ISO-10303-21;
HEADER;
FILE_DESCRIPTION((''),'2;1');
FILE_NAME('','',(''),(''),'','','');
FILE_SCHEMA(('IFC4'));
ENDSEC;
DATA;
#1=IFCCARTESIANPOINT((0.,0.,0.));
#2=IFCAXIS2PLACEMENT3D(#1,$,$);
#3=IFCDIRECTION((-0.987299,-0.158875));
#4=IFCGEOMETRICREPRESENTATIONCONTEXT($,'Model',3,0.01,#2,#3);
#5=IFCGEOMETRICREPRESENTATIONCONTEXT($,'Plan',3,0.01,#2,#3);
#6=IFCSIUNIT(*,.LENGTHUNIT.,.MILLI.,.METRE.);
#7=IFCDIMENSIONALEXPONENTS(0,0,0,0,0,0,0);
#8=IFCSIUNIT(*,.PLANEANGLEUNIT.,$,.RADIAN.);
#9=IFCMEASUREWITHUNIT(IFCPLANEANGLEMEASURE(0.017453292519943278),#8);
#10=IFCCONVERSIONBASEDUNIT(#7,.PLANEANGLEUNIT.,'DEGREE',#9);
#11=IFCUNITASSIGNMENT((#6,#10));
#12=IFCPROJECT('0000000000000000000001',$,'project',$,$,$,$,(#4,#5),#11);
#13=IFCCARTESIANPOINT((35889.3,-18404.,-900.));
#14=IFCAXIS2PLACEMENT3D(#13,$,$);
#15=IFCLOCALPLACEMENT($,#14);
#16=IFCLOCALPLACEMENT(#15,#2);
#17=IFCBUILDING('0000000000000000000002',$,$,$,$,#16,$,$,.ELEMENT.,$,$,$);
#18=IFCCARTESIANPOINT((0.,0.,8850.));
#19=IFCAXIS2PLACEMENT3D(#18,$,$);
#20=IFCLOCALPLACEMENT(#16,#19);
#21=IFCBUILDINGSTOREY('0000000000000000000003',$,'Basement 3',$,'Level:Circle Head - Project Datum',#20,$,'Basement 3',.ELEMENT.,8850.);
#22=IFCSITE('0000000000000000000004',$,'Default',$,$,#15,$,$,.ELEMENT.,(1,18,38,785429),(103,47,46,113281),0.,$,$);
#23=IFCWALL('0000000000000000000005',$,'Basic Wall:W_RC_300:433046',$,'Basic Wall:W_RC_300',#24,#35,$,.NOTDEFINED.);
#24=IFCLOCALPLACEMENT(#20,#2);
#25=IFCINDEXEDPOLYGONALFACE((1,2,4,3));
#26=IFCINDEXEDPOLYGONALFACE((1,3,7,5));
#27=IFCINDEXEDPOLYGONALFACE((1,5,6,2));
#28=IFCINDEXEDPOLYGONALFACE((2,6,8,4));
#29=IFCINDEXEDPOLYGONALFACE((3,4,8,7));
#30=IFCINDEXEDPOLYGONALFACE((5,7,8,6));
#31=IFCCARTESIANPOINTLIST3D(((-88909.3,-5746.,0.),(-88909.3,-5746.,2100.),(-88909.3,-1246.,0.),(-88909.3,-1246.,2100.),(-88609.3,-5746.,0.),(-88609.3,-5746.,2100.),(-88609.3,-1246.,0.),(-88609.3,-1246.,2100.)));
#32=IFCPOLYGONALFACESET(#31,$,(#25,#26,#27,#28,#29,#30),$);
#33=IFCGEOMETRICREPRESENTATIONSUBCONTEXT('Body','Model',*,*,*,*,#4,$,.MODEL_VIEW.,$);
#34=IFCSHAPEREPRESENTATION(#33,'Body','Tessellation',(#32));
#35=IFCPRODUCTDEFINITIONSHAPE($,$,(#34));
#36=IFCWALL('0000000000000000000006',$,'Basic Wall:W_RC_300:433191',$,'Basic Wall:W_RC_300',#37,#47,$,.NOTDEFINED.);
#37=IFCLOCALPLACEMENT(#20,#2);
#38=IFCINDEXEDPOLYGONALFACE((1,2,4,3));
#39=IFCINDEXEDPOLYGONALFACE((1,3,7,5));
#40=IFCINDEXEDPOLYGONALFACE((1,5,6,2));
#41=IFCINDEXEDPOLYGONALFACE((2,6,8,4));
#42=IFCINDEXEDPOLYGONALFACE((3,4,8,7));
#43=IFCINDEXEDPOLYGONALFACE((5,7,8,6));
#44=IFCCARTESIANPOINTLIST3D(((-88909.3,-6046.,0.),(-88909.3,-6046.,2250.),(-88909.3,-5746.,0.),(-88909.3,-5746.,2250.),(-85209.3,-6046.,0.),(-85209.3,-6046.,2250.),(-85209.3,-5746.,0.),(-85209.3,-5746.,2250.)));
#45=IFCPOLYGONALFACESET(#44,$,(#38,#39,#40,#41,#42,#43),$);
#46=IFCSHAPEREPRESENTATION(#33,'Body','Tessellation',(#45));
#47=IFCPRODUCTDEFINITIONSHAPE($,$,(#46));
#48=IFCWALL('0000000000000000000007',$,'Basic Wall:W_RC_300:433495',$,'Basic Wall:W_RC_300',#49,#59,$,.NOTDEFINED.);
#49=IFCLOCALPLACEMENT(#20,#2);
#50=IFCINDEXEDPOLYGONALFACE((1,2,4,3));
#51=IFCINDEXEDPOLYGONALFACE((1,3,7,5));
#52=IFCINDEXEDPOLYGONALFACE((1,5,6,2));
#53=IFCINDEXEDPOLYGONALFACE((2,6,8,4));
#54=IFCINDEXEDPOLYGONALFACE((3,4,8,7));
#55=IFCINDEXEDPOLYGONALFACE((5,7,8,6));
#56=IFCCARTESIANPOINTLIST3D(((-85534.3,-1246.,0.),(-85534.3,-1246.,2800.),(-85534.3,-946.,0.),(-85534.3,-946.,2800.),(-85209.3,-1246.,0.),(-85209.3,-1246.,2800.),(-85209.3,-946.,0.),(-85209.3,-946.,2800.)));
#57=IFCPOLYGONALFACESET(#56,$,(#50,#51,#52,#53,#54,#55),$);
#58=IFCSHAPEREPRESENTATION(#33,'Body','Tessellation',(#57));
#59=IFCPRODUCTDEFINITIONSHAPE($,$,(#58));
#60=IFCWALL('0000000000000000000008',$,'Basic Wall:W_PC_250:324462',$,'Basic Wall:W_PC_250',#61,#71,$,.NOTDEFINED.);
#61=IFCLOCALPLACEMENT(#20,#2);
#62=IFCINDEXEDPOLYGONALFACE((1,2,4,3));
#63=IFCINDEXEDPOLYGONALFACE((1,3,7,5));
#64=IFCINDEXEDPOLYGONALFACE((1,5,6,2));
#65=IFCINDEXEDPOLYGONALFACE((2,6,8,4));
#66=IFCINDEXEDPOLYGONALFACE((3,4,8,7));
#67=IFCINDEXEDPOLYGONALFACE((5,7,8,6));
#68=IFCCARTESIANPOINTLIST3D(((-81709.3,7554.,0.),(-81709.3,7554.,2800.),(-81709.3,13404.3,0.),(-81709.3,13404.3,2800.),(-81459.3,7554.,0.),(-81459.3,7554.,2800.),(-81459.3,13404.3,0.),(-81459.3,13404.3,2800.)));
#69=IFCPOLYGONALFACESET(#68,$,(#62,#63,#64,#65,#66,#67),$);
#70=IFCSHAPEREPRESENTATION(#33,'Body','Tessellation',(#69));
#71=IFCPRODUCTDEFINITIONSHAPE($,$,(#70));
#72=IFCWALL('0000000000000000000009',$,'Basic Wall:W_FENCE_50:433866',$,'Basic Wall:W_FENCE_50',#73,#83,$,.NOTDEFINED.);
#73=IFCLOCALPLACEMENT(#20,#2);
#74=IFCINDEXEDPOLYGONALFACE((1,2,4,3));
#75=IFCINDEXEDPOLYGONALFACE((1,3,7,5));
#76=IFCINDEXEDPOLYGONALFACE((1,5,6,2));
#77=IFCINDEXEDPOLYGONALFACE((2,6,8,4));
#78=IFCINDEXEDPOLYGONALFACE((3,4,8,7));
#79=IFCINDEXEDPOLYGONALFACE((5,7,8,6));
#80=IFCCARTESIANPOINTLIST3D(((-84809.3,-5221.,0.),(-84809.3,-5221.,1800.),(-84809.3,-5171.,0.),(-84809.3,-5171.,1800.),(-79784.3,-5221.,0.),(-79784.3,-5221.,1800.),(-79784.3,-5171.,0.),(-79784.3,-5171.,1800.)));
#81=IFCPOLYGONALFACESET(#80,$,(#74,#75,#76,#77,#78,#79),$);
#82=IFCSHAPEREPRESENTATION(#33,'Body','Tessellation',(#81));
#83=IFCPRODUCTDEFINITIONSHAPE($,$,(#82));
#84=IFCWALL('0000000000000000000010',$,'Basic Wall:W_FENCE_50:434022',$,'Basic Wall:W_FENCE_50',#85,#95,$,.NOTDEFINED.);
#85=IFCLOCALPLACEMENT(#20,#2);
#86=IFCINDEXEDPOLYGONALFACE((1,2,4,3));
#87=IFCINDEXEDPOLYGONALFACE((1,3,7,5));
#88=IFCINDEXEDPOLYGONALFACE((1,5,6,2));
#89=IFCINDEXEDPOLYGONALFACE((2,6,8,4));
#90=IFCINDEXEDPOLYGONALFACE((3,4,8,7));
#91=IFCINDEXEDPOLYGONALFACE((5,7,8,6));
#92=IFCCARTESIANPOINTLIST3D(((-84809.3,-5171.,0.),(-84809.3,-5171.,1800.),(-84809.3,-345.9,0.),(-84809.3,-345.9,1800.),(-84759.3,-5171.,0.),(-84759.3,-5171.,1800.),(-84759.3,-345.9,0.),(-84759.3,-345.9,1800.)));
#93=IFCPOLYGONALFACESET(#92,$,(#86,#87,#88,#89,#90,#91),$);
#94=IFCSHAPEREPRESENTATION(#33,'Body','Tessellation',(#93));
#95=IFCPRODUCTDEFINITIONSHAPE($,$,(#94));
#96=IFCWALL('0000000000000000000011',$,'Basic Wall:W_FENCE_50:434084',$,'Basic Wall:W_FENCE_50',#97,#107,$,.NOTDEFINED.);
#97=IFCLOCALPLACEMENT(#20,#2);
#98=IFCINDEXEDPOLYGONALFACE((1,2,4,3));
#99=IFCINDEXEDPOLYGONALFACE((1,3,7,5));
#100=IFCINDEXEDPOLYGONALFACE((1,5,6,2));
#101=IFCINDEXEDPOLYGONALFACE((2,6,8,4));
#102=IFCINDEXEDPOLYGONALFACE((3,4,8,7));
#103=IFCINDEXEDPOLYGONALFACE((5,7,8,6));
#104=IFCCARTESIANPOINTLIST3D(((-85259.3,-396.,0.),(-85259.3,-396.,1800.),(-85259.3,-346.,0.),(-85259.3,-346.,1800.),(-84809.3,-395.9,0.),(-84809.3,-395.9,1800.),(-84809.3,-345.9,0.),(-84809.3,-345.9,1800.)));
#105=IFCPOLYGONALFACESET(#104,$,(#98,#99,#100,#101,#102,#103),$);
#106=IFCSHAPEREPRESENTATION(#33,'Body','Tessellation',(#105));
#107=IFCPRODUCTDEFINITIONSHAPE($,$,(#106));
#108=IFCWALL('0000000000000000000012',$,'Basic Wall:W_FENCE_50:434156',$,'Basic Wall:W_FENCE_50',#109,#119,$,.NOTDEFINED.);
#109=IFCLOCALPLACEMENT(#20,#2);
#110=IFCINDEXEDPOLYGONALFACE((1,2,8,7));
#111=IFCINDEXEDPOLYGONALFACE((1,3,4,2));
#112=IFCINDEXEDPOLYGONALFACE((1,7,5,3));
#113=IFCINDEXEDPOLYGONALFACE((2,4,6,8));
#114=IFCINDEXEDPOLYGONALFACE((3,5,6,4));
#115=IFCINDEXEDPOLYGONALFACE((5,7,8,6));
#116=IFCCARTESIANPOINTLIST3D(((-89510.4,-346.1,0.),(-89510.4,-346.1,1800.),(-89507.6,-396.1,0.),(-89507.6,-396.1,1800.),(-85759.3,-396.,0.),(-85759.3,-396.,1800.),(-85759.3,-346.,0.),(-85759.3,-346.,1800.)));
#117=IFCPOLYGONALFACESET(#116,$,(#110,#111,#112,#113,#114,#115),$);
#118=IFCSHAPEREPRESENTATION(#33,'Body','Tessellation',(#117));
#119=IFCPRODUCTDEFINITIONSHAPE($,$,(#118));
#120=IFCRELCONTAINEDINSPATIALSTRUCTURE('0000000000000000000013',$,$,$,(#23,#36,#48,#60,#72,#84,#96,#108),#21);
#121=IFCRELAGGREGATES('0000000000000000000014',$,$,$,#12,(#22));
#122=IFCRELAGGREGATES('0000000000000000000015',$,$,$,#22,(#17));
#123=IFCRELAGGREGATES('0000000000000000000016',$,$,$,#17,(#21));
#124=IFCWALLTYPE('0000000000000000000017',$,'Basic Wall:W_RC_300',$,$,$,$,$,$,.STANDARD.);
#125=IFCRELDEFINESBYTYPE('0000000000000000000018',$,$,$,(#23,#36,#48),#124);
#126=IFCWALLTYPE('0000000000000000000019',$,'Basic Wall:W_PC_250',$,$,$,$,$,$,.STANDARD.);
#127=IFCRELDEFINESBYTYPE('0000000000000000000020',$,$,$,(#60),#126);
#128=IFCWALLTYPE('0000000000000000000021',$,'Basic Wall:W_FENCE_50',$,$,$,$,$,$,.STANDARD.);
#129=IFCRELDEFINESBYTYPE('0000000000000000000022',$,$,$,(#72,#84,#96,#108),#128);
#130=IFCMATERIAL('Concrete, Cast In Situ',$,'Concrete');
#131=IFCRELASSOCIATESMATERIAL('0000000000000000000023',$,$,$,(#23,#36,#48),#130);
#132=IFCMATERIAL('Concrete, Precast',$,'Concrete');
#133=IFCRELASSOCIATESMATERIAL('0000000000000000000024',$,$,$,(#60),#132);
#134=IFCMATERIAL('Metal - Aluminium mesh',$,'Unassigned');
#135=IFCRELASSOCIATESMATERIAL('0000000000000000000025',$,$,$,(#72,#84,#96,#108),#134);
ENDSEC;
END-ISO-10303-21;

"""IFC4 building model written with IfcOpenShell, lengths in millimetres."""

from ifc_helpers import new_model, entity, si_unit, converted_unit, direction, frame, origin, place, context, subcontext, project, spatial, indexed_curve, outline, extrude, material, type_object, element, save


model = new_model("IFC4")

# Units and contexts
model_context = context("Model", 3, precision=0.01, world=origin(), true_north=direction((-0.987299, -0.158875)))
plan_context = context("Plan", 3, precision=0.01, world=origin(), true_north=direction((-0.987299, -0.158875)))
body_context = subcontext(model_context, "Body", "Model", "MODEL_VIEW")
ifc_project = project(units=[si_unit("LENGTHUNIT", "METRE", prefix="MILLI"), converted_unit("PLANEANGLEUNIT", "DEGREE", entity("IfcPlaneAngleMeasure", 0.017453292519943278), si_unit("PLANEANGLEUNIT", "RADIAN"), dimensions=[0, 0, 0, 0, 0, 0, 0])], contexts=[model_context, plan_context])

# Site, building, storey
site_placement = place(None, frame((35889.3, -18404.0, -900.0)))
site = spatial("IfcSite", under=ifc_project, at=site_placement, Name="Default", CompositionType="ELEMENT", RefLatitude=(1, 18, 38, 785429), RefLongitude=(103, 47, 46, 113281), RefElevation=0.0)
building_placement = place(site_placement, origin())
building = spatial("IfcBuilding", under=site, at=building_placement, CompositionType="ELEMENT")
storey_placement = place(building_placement, frame((0.0, 0.0, 8850.0)))
storey = spatial("IfcBuildingStorey", under=building, at=storey_placement, Name="Basement 3", ObjectType="Level:Circle Head - Project Datum", LongName="Basement 3", CompositionType="ELEMENT", Elevation=8850.0)

# Shared definitions
ifc_material_1 = material(Name="Concrete, Precast", Category="Concrete")

# Walls
ifc_material_2 = material(Name="Concrete, Cast In Situ", Category="Concrete")
wall_type_1 = type_object("IfcWallType", Name="Basic Wall:W_RC_300", PredefinedType="STANDARD")
wall_1_placement = place(storey_placement, frame((-88759.3, -1246.0, 0.0), z_axis=(0.0, 0.0, 1.0), x_axis=(0.0, -1.0, 0.0)))
element("IfcWall", 1, at=wall_1_placement, inside=storey, type_object=wall_type_1, material=ifc_material_2, Name="Basic Wall:W_RC_300:433046", ObjectType="Basic Wall:W_RC_300", PredefinedType="NOTDEFINED", context=body_context, shape_type="SweptSolid", body=[
    extrude(outline(indexed_curve([(4500.0, 150.0), (0.0, 150.0), (0.0, -150.0), (4500.0, -150.0), (4500.0, 150.0)], self_intersect=False)), origin(), (0.0, 0.0, 1.0), 2100.0),
])
wall_2_placement = place(storey_placement, frame((-88909.3, -5896.0, 0.0)))
element("IfcWall", 2, at=wall_2_placement, inside=storey, type_object=wall_type_1, material=ifc_material_2, Name="Basic Wall:W_RC_300:433191", ObjectType="Basic Wall:W_RC_300", PredefinedType="NOTDEFINED", context=body_context, shape_type="SweptSolid", body=[
    extrude(outline(indexed_curve([(3700.0, 150.0), (0.0, 150.0), (0.0, -150.0), (3700.0, -150.0), (3700.0, 150.0)], self_intersect=False)), origin(), (0.0, 0.0, 1.0), 2250.0),
])
wall_3_placement = place(storey_placement, frame((-85534.3, -1096.0, 0.0)))
element("IfcWall", 3, at=wall_3_placement, inside=storey, type_object=wall_type_1, material=ifc_material_2, Name="Basic Wall:W_RC_300:433495", ObjectType="Basic Wall:W_RC_300", PredefinedType="NOTDEFINED", context=body_context, shape_type="SweptSolid", body=[
    extrude(outline(indexed_curve([(325.0, 150.0), (0.0, 150.0), (0.0, -150.0), (325.0, -150.0), (325.0, 150.0)], self_intersect=False)), origin(), (0.0, 0.0, 1.0), 2800.0),
])
wall_type_2 = type_object("IfcWallType", Name="Basic Wall:W_PC_250", PredefinedType="STANDARD")
wall_4_placement = place(storey_placement, frame((-81584.3, 7554.0, 0.0), z_axis=(0.0, 0.0, 1.0), x_axis=(0.0, 1.0, 0.0)))
element("IfcWall", 4, at=wall_4_placement, inside=storey, type_object=wall_type_2, material=ifc_material_1, Name="Basic Wall:W_PC_250:324462", ObjectType="Basic Wall:W_PC_250", PredefinedType="NOTDEFINED", context=body_context, shape_type="SweptSolid", body=[
    extrude(outline(indexed_curve([(5850.3, 125.0), (0.0, 125.0), (0.0, -125.0), (5850.3, -125.0), (5850.3, 125.0)], self_intersect=False)), origin(), (0.0, 0.0, 1.0), 2800.0),
])
ifc_material_3 = material(Name="Metal - Aluminium mesh", Category="Unassigned")
wall_type_3 = type_object("IfcWallType", Name="Basic Wall:W_FENCE_50", PredefinedType="STANDARD")
wall_5_placement = place(storey_placement, frame((-79784.3, -5196.0, 0.0), z_axis=(0.0, 0.0, 1.0), x_axis=(-1.0, 0.0, 0.0)))
element("IfcWall", 5, at=wall_5_placement, inside=storey, type_object=wall_type_3, material=ifc_material_3, Name="Basic Wall:W_FENCE_50:433866", ObjectType="Basic Wall:W_FENCE_50", PredefinedType="NOTDEFINED", context=body_context, shape_type="SweptSolid", body=[
    extrude(outline(indexed_curve([(5025.0, 25.0), (0.0, 25.0), (0.0, -25.0), (5025.0, -25.0), (5025.0, 25.0)], self_intersect=False)), origin(), (0.0, 0.0, 1.0), 1800.0),
])
wall_6_placement = place(storey_placement, frame((-84784.3, -5171.0, 0.0), z_axis=(0.0, 0.0, 1.0), x_axis=(0.0, 1.0, 0.0)))
element("IfcWall", 6, at=wall_6_placement, inside=storey, type_object=wall_type_3, material=ifc_material_3, Name="Basic Wall:W_FENCE_50:434022", ObjectType="Basic Wall:W_FENCE_50", PredefinedType="NOTDEFINED", context=body_context, shape_type="SweptSolid", body=[
    extrude(outline(indexed_curve([(4825.0, 25.0), (0.0, 25.0), (0.0, -25.0), (4825.0, -25.0), (4825.0, 25.0)], self_intersect=False)), origin(), (0.0, 0.0, 1.0), 1800.0),
])
wall_7_placement = place(storey_placement, frame((-84809.3, -370.9, 0.0), z_axis=(0.0, 0.0, 1.0), x_axis=(-1.0, -0.000028, 0.0)))
element("IfcWall", 7, at=wall_7_placement, inside=storey, type_object=wall_type_3, material=ifc_material_3, Name="Basic Wall:W_FENCE_50:434084", ObjectType="Basic Wall:W_FENCE_50", PredefinedType="NOTDEFINED", context=body_context, shape_type="SweptSolid", body=[
    extrude(outline(indexed_curve([(450.0, 25.0), (0.0, 25.0), (0.0, -25.0), (450.0, -25.0), (450.0, 25.0)], self_intersect=False)), origin(), (0.0, 0.0, 1.0), 1800.0),
])
wall_8_placement = place(storey_placement, frame((-85759.3, -371.0, 0.0), z_axis=(0.0, 0.0, 1.0), x_axis=(-1.0, -0.000028, 0.0)))
element("IfcWall", 8, at=wall_8_placement, inside=storey, type_object=wall_type_3, material=ifc_material_3, Name="Basic Wall:W_FENCE_50:434156", ObjectType="Basic Wall:W_FENCE_50", PredefinedType="NOTDEFINED", context=body_context, shape_type="SweptSolid", body=[
    extrude(outline(indexed_curve([(3751.1, -25.0), (3748.3, 25.0), (0.0, 25.0), (0.0, -25.0), (3751.1, -25.0)], self_intersect=False)), origin(), (0.0, 0.0, 1.0), 1800.0),
])

save(model, "model.ifc")
